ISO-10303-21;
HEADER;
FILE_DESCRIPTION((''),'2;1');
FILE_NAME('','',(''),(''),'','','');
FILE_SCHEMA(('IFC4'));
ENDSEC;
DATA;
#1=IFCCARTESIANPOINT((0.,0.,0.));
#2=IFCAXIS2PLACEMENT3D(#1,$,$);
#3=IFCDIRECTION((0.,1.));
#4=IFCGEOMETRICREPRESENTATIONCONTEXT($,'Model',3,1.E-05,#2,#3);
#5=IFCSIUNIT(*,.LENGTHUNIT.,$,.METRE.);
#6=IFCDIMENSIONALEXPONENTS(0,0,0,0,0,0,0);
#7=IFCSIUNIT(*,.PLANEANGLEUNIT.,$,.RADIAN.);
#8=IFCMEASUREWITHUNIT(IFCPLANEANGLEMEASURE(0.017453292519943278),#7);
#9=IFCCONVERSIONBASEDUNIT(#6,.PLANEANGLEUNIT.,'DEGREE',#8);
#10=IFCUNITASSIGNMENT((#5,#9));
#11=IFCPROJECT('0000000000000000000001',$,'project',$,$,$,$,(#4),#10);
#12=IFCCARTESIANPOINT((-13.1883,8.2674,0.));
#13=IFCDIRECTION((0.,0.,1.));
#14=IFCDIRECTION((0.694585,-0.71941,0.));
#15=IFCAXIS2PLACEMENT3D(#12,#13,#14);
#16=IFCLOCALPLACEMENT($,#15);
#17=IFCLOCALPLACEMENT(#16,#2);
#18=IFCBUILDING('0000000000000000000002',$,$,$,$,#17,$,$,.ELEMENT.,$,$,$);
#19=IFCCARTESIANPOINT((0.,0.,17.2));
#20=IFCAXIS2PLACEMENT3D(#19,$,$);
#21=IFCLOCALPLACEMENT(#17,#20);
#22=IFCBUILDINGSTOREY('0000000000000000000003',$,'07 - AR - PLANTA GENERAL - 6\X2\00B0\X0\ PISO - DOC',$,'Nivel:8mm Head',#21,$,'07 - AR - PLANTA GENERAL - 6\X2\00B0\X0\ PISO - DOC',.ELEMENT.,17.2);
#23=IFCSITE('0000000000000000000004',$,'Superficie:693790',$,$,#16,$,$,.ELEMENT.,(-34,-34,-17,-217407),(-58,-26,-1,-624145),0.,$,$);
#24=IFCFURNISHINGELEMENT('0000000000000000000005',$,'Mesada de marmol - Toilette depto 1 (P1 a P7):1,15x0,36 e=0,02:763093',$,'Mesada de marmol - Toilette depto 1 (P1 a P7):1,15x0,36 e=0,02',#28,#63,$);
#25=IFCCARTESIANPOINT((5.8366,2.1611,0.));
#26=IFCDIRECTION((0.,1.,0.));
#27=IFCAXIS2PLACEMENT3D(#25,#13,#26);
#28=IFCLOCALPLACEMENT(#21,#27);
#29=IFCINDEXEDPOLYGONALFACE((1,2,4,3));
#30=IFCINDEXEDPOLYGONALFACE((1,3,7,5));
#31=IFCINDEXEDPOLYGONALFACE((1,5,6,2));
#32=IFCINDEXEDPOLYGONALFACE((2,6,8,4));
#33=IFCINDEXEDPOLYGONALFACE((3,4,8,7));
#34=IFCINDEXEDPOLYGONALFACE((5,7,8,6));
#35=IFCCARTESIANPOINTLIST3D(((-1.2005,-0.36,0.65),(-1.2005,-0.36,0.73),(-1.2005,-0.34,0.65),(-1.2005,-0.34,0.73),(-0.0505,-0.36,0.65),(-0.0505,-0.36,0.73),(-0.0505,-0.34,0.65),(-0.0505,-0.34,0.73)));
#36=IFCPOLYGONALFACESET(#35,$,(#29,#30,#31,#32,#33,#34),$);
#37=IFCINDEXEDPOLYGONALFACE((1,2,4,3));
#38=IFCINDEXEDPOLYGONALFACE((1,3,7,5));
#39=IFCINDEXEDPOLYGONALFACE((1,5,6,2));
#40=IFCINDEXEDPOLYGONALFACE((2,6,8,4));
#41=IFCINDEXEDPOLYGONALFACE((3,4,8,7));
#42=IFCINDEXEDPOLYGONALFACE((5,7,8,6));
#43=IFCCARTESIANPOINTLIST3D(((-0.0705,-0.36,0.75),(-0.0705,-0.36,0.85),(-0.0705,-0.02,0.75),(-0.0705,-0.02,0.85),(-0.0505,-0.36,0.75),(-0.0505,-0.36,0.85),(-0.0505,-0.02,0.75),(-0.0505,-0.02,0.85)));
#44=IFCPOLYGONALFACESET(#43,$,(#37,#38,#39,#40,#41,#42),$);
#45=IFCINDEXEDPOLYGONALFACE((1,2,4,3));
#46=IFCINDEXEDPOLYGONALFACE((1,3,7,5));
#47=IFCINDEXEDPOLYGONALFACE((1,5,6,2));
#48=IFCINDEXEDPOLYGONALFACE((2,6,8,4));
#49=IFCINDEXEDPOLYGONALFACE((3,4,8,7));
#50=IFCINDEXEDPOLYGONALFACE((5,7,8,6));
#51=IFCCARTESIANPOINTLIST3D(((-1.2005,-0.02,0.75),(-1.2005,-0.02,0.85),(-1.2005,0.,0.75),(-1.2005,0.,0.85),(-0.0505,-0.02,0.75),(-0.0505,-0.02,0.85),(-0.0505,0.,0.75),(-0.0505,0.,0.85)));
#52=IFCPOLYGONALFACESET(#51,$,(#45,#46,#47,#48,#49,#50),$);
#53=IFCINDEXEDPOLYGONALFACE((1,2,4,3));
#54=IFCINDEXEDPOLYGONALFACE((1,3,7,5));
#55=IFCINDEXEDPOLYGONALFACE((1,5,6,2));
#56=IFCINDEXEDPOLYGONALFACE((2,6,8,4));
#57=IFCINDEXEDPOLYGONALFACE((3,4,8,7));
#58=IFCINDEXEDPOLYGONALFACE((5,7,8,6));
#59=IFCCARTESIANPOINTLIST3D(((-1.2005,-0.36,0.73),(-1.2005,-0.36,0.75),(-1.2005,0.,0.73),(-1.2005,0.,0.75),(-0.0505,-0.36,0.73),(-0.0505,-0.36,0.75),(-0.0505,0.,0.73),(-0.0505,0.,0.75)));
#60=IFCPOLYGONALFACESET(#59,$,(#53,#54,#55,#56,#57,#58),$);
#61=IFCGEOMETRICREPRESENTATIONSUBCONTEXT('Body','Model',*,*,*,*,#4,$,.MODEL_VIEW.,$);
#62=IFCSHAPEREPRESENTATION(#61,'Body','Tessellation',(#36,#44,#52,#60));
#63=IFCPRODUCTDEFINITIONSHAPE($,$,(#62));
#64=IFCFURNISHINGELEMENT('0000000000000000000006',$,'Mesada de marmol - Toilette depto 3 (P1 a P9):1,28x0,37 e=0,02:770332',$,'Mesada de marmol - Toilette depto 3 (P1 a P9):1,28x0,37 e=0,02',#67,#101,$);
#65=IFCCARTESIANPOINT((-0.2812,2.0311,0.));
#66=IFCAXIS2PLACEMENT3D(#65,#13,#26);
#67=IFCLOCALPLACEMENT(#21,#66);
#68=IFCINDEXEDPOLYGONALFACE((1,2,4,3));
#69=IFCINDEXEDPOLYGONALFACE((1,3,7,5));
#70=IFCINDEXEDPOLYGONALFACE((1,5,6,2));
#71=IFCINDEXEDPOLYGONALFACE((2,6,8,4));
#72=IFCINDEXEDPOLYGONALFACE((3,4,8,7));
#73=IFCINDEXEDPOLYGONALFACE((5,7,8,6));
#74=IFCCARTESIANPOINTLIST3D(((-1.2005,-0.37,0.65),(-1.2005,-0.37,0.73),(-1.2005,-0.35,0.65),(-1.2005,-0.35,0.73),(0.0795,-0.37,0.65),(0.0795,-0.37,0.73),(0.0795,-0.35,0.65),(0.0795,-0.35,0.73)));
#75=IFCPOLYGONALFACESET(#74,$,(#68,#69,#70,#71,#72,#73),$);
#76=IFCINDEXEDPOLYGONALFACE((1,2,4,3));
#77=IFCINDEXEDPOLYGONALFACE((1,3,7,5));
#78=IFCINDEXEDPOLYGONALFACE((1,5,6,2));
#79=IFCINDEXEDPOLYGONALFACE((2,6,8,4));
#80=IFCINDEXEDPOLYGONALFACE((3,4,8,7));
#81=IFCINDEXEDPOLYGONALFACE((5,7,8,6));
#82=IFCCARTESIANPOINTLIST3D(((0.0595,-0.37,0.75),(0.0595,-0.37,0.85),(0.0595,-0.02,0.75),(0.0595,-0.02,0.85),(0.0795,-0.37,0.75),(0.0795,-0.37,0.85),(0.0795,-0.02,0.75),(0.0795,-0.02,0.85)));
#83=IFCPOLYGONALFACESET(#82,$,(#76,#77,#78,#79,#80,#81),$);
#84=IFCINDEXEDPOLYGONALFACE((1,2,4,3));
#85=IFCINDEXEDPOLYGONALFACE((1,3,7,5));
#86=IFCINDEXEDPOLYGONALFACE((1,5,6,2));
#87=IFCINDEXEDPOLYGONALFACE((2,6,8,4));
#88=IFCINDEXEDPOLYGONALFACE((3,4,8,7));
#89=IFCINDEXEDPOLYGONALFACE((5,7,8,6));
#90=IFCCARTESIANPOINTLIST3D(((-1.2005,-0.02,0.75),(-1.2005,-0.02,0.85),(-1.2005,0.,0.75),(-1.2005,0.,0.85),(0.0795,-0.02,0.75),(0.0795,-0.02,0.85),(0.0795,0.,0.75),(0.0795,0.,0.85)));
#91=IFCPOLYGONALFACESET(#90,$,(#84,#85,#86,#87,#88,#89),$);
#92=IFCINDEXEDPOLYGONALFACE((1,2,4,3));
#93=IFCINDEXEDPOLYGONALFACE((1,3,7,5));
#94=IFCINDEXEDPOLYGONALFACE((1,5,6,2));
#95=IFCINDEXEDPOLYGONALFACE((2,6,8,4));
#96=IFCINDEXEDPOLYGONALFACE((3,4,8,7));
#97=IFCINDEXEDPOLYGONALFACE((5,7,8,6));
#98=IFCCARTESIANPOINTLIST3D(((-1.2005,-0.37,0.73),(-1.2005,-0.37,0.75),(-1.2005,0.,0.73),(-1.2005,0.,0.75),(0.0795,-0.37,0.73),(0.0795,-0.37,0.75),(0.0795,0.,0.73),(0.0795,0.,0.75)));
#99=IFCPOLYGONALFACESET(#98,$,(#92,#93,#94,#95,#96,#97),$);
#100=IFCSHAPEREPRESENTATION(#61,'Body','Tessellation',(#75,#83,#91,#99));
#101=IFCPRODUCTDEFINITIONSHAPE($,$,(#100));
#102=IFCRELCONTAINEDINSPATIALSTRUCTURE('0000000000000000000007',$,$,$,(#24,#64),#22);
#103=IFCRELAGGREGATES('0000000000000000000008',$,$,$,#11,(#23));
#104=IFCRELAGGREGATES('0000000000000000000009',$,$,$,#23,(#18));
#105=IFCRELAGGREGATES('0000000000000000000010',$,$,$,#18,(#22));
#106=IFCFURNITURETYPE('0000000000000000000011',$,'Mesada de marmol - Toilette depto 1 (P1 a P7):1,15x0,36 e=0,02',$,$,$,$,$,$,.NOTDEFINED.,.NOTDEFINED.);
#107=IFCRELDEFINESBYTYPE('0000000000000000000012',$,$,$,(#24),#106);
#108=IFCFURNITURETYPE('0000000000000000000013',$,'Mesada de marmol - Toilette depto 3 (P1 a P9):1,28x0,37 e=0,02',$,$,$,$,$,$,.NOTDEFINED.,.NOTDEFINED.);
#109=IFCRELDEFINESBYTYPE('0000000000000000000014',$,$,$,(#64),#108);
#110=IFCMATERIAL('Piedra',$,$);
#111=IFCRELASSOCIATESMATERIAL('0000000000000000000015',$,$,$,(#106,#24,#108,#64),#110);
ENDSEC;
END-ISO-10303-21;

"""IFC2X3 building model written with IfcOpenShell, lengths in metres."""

from ifc_helpers import new_model, entity, si_unit, converted_unit, direction, frame, frame_2d, origin, origin_2d_with_axis, place, context, subcontext, project, spatial, rectangle, extrude, source, transform, mapped, material, type_object, type_shapes, element, save


model = new_model("IFC2X3")

# Units and contexts
model_context = context("Model", 3, precision=1e-05, world=origin(), true_north=direction((0.0, 1.0)))
body_context = subcontext(model_context, "Body", "Model", "MODEL_VIEW")
ifc_project = project(units=[si_unit("LENGTHUNIT", "METRE"), converted_unit("PLANEANGLEUNIT", "DEGREE", entity("IfcPlaneAngleMeasure", 0.017453292519943278), si_unit("PLANEANGLEUNIT", "RADIAN"), dimensions=[0, 0, 0, 0, 0, 0, 0])], contexts=[model_context])

# Site, building, storey
site_placement = place(None, frame((-13.1883, 8.2674, 0.0), z_axis=(0.0, 0.0, 1.0), x_axis=(0.694585, -0.71941, 0.0)))
site = spatial("IfcSite", under=ifc_project, at=site_placement, Name="Superficie:693790", CompositionType="ELEMENT", RefLatitude=(-34, -34, -17, -217407), RefLongitude=(-58, -26, -1, -624145), RefElevation=0.0)
building_placement = place(site_placement, origin())
building = spatial("IfcBuilding", under=site, at=building_placement, CompositionType="ELEMENT")
storey_placement = place(building_placement, frame((0.0, 0.0, 17.2)))
storey = spatial("IfcBuildingStorey", under=building, at=storey_placement, Name="07 - AR - PLANTA GENERAL - 6° PISO - DOC", ObjectType="Nivel:8mm Head", LongName="07 - AR - PLANTA GENERAL - 6° PISO - DOC", CompositionType="ELEMENT", Elevation=17.2)

# Furnishing elements
ifc_material_1 = material(Name="Piedra")
furniture_type_1 = type_object("IfcFurnitureType", Name="Mesada de marmol - Toilette depto 1 (P1 a P7):1,15x0,36 e=0,02", AssemblyPlace="NOTDEFINED", material=ifc_material_1)
shared_shape_1 = source(origin(), body_context, "Body", "SweptSolid", [
    extrude(rectangle(XDim=0.02, YDim=1.15, at=frame_2d((0.0, 0.0), x_axis=(1.0, 0.0))), frame((-0.6255, -0.35, 0.65), z_axis=(0.0, 0.0, 1.0), x_axis=(0.0, 1.0, 0.0)), (0.0, 0.0, 1.0), 0.08),
    extrude(rectangle(XDim=0.02, YDim=0.34, at=origin_2d_with_axis()), frame((-0.0605, -0.19, 0.75), z_axis=(0.0, 0.0, 1.0), x_axis=(-1.0, 0.0, 0.0)), (0.0, 0.0, 1.0), 0.1),
    extrude(rectangle(XDim=0.02, YDim=1.15, at=frame_2d((0.0, 0.0), x_axis=(1.0, 0.0))), frame((-0.6255, -0.01, 0.75), z_axis=(0.0, 0.0, 1.0), x_axis=(0.0, -1.0, 0.0)), (0.0, 0.0, 1.0), 0.1),
    extrude(rectangle(XDim=1.15, YDim=0.36, at=frame_2d((0.0, 0.0), x_axis=(1.0, 0.0))), frame((-0.6255, -0.18, 0.73), z_axis=(0.0, 0.0, 1.0), x_axis=(-1.0, 0.0, 0.0)), (0.0, 0.0, 1.0), 0.02),
])
type_shapes(furniture_type_1, [shared_shape_1])
furnishing_1_placement = place(storey_placement, frame((5.8366, 2.1611, 0.0), z_axis=(0.0, 0.0, 1.0), x_axis=(0.0, 1.0, 0.0)))
element("IfcFurnishingElement", 1, at=furnishing_1_placement, inside=storey, type_object=furniture_type_1, material=ifc_material_1, Name="Mesada de marmol - Toilette depto 1 (P1 a P7):1,15x0,36 e=0,02:763093", ObjectType="Mesada de marmol - Toilette depto 1 (P1 a P7):1,15x0,36 e=0,02", context=body_context, shape_type="MappedRepresentation", body=[
    mapped(shared_shape_1, transform((0.0, 0.0, 0.0), scale=1.0)),
])
furniture_type_2 = type_object("IfcFurnitureType", Name="Mesada de marmol - Toilette depto 3 (P1 a P9):1,28x0,37 e=0,02", AssemblyPlace="NOTDEFINED", material=ifc_material_1)
shared_shape_2 = source(origin(), body_context, "Body", "SweptSolid", [
    extrude(rectangle(XDim=0.02, YDim=1.28, at=origin_2d_with_axis()), frame((-0.5605, -0.36, 0.65), z_axis=(0.0, 0.0, 1.0), x_axis=(0.0, 1.0, 0.0)), (0.0, 0.0, 1.0), 0.08),
    extrude(rectangle(XDim=0.02, YDim=0.35, at=frame_2d((0.0, 0.0), x_axis=(1.0, 0.0))), frame((0.0695, -0.195, 0.75), z_axis=(0.0, 0.0, 1.0), x_axis=(-1.0, 0.0, 0.0)), (0.0, 0.0, 1.0), 0.1),
    extrude(rectangle(XDim=0.02, YDim=1.28, at=origin_2d_with_axis()), frame((-0.5605, -0.01, 0.75), z_axis=(0.0, 0.0, 1.0), x_axis=(0.0, -1.0, 0.0)), (0.0, 0.0, 1.0), 0.1),
    extrude(rectangle(XDim=1.28, YDim=0.37, at=frame_2d((0.0, 0.0), x_axis=(1.0, 0.0))), frame((-0.5605, -0.185, 0.73), z_axis=(0.0, 0.0, 1.0), x_axis=(-1.0, 0.0, 0.0)), (0.0, 0.0, 1.0), 0.02),
])
type_shapes(furniture_type_2, [shared_shape_2])
furnishing_2_placement = place(storey_placement, frame((-0.2812, 2.0311, 0.0), z_axis=(0.0, 0.0, 1.0), x_axis=(0.0, 1.0, 0.0)))
element("IfcFurnishingElement", 2, at=furnishing_2_placement, inside=storey, type_object=furniture_type_2, material=ifc_material_1, Name="Mesada de marmol - Toilette depto 3 (P1 a P9):1,28x0,37 e=0,02:770332", ObjectType="Mesada de marmol - Toilette depto 3 (P1 a P9):1,28x0,37 e=0,02", context=body_context, shape_type="MappedRepresentation", body=[
    mapped(shared_shape_2, transform((0.0, 0.0, 0.0), scale=1.0)),
])

save(model, "model.ifc")
